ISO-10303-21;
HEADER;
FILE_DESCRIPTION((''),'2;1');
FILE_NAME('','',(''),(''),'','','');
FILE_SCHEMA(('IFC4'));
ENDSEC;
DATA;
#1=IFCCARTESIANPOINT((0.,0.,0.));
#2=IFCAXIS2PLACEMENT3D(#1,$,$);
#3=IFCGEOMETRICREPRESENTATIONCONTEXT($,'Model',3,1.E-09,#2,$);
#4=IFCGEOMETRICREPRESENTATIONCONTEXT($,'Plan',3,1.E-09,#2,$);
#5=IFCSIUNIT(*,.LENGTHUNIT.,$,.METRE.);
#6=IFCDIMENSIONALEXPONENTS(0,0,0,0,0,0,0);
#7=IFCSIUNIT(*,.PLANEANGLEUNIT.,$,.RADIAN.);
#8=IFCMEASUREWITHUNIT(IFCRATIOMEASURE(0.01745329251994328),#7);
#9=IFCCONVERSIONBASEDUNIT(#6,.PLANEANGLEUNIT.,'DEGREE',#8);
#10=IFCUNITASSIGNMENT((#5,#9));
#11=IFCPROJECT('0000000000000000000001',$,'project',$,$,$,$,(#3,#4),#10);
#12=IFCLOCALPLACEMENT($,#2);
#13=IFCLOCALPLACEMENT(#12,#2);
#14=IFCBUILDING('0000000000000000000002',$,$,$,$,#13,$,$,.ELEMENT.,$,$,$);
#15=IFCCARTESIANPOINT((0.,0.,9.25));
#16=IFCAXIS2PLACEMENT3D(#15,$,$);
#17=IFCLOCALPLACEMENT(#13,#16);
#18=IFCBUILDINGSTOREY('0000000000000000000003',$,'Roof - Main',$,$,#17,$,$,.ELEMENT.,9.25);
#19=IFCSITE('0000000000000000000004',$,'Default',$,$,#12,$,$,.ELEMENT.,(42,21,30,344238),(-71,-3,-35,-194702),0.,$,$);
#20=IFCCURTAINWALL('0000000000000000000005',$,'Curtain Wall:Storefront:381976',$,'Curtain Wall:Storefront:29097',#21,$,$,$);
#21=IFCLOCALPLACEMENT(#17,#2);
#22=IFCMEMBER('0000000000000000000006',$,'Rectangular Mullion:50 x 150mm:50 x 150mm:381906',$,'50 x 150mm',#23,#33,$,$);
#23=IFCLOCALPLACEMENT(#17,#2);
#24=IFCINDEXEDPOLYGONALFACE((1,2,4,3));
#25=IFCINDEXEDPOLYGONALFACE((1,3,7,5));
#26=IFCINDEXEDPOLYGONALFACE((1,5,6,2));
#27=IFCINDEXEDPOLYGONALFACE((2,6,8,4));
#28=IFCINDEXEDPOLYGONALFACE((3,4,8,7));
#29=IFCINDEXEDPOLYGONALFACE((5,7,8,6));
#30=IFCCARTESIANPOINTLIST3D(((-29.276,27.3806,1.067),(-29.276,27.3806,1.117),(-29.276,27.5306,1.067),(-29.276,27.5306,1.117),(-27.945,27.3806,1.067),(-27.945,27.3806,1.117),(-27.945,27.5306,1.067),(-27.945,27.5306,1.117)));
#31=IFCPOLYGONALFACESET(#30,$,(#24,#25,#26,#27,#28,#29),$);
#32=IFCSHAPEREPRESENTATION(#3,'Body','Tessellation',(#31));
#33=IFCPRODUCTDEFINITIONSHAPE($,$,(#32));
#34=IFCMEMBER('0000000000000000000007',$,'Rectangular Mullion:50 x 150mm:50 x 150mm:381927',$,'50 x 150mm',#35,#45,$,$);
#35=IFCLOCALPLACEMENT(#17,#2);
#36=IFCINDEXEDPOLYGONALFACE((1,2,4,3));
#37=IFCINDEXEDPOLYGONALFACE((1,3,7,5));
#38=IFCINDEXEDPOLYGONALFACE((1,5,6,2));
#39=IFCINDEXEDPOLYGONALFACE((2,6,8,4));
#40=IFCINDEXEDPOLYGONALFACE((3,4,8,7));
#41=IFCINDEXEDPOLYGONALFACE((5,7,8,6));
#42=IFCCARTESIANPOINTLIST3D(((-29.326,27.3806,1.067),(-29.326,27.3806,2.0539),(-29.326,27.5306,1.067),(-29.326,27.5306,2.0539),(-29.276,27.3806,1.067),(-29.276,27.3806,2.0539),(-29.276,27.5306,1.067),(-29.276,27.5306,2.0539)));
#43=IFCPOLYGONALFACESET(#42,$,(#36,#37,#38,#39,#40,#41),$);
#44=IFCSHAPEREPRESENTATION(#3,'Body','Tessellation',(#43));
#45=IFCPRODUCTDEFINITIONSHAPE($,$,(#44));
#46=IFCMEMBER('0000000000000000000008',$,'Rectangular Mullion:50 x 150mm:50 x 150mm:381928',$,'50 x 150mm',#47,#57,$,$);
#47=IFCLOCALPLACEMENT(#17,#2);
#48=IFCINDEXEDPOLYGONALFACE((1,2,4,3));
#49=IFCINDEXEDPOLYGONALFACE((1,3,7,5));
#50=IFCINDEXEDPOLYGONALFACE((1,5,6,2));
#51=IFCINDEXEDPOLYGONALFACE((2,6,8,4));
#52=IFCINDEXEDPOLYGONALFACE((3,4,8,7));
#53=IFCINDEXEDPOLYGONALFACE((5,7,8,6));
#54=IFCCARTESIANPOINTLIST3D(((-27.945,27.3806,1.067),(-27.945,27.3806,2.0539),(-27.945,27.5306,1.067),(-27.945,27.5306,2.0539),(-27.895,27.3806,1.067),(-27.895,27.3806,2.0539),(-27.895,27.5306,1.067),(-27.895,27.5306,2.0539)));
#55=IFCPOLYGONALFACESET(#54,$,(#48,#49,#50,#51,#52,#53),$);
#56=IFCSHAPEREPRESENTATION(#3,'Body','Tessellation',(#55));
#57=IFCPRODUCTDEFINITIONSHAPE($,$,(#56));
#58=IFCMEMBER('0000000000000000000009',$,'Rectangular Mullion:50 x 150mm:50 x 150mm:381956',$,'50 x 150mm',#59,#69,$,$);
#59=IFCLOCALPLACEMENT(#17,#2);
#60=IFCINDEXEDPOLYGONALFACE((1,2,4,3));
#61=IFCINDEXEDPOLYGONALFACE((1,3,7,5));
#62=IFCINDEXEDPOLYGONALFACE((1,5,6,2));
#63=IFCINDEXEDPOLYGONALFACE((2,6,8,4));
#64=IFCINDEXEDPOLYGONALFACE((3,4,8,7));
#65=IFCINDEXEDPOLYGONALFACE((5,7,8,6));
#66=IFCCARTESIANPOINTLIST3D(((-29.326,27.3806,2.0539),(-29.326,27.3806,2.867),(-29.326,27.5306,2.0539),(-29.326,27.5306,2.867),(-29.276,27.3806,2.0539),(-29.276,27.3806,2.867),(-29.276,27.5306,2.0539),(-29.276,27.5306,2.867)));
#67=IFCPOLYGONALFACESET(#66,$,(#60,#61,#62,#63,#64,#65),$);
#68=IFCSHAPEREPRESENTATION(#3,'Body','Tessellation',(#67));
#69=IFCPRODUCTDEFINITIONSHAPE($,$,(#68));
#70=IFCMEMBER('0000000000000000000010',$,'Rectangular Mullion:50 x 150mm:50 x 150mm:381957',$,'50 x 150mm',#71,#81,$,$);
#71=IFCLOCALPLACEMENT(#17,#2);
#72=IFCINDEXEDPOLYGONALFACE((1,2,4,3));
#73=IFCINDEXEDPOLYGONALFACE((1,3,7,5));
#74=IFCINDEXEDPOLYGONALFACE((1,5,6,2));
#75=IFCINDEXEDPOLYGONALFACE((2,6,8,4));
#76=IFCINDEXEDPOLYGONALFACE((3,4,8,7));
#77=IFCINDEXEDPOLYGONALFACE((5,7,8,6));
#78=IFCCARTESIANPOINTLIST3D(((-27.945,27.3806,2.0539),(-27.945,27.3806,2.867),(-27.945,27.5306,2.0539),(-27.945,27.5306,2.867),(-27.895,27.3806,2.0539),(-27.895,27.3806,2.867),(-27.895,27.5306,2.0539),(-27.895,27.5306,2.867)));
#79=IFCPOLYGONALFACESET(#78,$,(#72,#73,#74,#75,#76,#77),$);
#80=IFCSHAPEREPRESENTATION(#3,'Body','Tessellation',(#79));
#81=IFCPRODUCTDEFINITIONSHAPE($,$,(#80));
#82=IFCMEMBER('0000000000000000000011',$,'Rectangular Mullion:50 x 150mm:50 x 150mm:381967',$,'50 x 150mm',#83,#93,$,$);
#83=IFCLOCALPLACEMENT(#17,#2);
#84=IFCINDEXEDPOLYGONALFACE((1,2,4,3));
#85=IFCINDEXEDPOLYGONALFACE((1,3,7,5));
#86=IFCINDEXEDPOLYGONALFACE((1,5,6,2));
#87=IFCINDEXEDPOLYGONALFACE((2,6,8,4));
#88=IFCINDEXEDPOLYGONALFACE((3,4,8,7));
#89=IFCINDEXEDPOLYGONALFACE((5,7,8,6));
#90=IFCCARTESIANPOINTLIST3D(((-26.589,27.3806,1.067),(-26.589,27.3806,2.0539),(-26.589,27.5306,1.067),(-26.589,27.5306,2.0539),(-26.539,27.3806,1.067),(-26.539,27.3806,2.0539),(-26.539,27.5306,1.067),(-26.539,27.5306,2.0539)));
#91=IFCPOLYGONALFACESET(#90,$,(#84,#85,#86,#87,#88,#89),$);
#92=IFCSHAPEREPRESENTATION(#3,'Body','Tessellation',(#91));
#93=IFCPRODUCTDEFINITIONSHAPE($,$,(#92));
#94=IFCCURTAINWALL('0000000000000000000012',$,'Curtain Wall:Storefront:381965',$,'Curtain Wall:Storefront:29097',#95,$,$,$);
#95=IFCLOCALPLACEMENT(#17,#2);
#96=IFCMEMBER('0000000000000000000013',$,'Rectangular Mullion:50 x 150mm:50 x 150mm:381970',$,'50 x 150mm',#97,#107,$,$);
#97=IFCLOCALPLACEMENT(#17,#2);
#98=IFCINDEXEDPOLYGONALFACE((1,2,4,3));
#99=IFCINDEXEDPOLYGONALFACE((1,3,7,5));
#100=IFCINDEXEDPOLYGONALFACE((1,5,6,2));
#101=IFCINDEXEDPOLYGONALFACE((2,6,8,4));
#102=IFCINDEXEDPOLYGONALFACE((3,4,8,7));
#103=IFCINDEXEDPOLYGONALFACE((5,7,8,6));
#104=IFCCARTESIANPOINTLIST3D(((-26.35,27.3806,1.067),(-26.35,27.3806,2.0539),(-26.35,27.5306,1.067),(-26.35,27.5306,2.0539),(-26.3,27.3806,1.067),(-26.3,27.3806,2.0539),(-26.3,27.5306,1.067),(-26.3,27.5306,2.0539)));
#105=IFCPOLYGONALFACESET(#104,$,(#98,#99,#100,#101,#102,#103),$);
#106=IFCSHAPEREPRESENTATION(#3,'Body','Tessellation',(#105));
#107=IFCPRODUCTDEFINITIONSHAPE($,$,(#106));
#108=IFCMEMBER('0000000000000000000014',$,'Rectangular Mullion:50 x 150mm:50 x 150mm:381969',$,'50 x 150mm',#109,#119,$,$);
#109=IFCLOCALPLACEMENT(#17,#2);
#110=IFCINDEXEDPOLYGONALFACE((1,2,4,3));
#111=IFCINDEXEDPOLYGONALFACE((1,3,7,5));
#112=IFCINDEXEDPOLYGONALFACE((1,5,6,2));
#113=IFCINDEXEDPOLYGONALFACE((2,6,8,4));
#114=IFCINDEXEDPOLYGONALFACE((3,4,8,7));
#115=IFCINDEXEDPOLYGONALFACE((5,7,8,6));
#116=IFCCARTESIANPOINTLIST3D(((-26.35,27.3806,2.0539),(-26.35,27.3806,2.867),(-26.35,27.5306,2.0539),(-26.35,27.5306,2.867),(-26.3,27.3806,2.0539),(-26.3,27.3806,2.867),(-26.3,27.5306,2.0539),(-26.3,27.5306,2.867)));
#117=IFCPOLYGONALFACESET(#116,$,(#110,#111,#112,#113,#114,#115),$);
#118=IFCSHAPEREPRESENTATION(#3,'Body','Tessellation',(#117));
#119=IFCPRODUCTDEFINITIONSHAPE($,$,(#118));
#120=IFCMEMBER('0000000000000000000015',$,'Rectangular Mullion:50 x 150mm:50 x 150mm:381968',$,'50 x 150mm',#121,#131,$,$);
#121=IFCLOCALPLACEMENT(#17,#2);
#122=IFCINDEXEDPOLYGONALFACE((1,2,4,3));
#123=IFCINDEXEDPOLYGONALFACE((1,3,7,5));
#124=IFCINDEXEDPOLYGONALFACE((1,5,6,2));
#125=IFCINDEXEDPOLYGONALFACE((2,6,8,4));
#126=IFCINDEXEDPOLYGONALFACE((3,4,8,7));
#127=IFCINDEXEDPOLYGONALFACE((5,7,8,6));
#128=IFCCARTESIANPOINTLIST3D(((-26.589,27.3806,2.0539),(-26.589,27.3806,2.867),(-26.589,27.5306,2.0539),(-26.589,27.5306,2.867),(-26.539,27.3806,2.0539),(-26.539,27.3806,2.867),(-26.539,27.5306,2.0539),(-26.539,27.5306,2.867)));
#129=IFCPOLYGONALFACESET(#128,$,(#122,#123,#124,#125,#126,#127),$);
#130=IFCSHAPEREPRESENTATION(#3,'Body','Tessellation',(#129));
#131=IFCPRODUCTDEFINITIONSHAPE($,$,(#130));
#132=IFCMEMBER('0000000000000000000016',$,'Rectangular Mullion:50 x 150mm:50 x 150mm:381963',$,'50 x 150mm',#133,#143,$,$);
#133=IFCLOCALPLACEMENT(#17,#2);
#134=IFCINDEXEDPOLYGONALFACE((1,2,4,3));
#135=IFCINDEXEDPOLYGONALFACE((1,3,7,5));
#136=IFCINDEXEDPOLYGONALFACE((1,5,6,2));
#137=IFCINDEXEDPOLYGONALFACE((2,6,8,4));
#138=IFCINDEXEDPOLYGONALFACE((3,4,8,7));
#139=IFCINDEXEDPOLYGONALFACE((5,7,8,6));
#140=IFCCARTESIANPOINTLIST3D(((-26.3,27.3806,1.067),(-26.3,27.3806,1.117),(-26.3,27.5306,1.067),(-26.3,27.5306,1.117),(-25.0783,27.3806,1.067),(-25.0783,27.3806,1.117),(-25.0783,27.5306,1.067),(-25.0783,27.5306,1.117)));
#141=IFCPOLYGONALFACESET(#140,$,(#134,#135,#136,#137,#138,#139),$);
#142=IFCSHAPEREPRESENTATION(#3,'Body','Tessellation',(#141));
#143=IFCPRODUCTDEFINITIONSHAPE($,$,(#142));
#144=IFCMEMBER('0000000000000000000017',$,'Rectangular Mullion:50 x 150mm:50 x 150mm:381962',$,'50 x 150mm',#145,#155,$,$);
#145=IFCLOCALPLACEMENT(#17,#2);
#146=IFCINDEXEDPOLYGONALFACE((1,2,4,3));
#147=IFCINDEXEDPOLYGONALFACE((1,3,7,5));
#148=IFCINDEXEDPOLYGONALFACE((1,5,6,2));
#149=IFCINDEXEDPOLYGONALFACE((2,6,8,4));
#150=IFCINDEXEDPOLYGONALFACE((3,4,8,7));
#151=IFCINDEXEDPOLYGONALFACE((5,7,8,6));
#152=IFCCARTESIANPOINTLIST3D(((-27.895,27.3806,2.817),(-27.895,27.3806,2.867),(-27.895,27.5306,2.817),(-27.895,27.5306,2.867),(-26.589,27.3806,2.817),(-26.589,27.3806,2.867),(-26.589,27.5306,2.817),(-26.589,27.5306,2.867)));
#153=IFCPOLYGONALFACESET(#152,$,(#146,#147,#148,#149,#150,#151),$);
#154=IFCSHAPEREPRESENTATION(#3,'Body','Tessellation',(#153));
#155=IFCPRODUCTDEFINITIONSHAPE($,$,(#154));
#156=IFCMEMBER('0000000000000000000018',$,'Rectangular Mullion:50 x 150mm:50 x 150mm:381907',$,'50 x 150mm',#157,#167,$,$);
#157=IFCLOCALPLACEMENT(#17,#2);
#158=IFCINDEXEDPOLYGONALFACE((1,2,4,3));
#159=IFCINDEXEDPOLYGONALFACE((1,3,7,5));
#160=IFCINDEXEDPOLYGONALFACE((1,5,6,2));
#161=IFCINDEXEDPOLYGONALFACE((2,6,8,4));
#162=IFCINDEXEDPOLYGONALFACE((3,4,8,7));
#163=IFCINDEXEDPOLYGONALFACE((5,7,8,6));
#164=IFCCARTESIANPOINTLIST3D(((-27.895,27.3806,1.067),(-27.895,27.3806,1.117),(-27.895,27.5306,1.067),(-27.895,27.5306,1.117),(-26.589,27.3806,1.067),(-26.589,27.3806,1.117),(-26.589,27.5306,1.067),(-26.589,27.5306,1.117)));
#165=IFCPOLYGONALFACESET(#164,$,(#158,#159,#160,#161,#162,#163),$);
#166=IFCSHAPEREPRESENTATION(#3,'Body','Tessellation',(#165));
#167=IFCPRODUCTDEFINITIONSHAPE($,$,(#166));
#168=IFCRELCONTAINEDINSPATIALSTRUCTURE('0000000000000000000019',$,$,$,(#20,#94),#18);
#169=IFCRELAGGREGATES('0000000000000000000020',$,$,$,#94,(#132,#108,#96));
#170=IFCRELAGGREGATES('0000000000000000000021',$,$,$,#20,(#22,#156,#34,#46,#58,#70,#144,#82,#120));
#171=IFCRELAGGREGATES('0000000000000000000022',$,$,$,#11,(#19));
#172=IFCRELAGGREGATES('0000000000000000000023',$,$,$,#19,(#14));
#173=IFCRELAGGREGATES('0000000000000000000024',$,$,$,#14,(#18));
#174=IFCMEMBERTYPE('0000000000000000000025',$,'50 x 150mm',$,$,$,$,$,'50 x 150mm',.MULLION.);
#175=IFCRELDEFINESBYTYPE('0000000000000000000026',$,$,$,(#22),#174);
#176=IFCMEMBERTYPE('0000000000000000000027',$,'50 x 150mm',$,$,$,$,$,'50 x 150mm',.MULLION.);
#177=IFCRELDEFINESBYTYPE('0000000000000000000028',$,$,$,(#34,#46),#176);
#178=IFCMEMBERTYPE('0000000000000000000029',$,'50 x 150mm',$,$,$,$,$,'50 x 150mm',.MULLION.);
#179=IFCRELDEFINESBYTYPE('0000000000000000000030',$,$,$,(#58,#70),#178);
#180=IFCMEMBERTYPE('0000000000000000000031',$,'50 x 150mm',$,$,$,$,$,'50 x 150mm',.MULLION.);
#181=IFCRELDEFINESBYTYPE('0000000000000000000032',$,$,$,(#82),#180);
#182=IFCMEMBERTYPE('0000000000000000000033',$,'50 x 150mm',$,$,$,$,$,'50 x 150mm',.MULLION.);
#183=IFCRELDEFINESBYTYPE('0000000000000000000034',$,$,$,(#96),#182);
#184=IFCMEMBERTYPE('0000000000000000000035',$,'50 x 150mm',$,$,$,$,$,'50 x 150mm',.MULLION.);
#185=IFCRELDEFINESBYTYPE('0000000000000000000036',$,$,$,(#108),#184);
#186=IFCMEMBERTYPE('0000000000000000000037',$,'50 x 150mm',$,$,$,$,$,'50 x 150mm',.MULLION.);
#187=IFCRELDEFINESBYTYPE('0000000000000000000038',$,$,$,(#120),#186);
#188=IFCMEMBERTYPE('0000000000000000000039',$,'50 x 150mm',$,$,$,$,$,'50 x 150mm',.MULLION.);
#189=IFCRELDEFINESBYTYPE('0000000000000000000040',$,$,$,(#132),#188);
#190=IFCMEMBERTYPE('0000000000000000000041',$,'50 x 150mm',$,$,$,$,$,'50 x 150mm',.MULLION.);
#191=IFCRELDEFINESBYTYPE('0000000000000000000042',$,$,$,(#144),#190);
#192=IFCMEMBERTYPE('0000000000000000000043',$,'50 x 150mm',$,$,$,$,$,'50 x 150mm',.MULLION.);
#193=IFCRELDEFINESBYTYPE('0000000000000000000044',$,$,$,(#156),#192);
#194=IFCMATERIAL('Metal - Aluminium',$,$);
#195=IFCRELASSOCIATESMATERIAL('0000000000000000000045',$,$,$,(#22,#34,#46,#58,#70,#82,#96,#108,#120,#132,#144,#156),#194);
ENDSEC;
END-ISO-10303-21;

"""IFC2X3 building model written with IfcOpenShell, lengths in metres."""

from ifc_helpers import new_model, entity, si_unit, converted_unit, frame, origin, origin_2d_with_axis, place, context, project, spatial, rectangle, extrude, source, transform, mapped, material, type_object, type_shapes, element, aggregate, save


model = new_model("IFC2X3")

# Units and contexts
model_context = context("Model", 3, precision=1e-09, world=origin())
plan_context = context("Plan", 3, precision=1e-09, world=origin())
ifc_project = project(units=[si_unit("LENGTHUNIT", "METRE"), converted_unit("PLANEANGLEUNIT", "DEGREE", entity("IfcRatioMeasure", 0.01745329251994328), si_unit("PLANEANGLEUNIT", "RADIAN"), dimensions=[0, 0, 0, 0, 0, 0, 0])], contexts=[model_context, plan_context])

# Site, building, storey
site_placement = place(None, origin())
site = spatial("IfcSite", under=ifc_project, at=site_placement, Name="Default", CompositionType="ELEMENT", RefLatitude=(42, 21, 30, 344238), RefLongitude=(-71, -3, -35, -194702), RefElevation=0.0)
building_placement = place(site_placement, origin())
building = spatial("IfcBuilding", under=site, at=building_placement, CompositionType="ELEMENT")
storey_placement = place(building_placement, frame((0.0, 0.0, 9.25)))
storey = spatial("IfcBuildingStorey", under=building, at=storey_placement, Name="Roof - Main", CompositionType="ELEMENT", Elevation=9.25)

# Curtain walls, members
curtain_wall_1_placement = place(storey_placement, origin())
curtain_wall_1 = element("IfcCurtainWall", 1, at=curtain_wall_1_placement, inside=storey, Name="Curtain Wall:Storefront:381976", ObjectType="Curtain Wall:Storefront:29097")
ifc_material_1 = material(Name="Metal - Aluminium")
member_type_1 = type_object("IfcMemberType", Name="50 x 150mm", ElementType="50 x 150mm", PredefinedType="MULLION")
shared_shape_1 = source(origin(), model_context, "Body", "SweptSolid", [
    extrude(rectangle(XDim=0.05, YDim=0.15, at=origin_2d_with_axis()), frame((-0.025, 0.0, -1.331), z_axis=(0.0, 0.0, 1.0), x_axis=(-1.0, 0.0, 0.0)), (0.0, 0.0, 1.0), 1.331),
])
type_shapes(member_type_1, [shared_shape_1])
member_1_placement = place(storey_placement, frame((-29.276, 27.4556, 1.067), z_axis=(-1.0, 0.0, 0.0), x_axis=(0.0, 0.0, -1.0)))
member_1 = element("IfcMember", 2, at=member_1_placement, type_object=member_type_1, material=ifc_material_1, Name="Rectangular Mullion:50 x 150mm:50 x 150mm:381906", ObjectType="50 x 150mm", context=model_context, shape_type="MappedRepresentation", body=[
    mapped(shared_shape_1, transform((0.0, 0.0, 0.0), scale=1.0)),
])
member_type_2 = type_object("IfcMemberType", Name="50 x 150mm", ElementType="50 x 150mm", PredefinedType="MULLION")
shared_shape_2 = source(origin(), model_context, "Body", "SweptSolid", [
    extrude(rectangle(XDim=0.05, YDim=0.15, at=origin_2d_with_axis()), frame((0.0, 0.0, -0.9869), z_axis=(0.0, 0.0, 1.0), x_axis=(-1.0, 0.0, 0.0)), (0.0, 0.0, 1.0), 0.9869),
])
type_shapes(member_type_2, [shared_shape_2])
member_2_placement = place(storey_placement, frame((-29.301, 27.4556, 1.067), z_axis=(0.0, 0.0, -1.0), x_axis=(1.0, 0.0, 0.0)))
member_2 = element("IfcMember", 3, at=member_2_placement, type_object=member_type_2, material=ifc_material_1, Name="Rectangular Mullion:50 x 150mm:50 x 150mm:381927", ObjectType="50 x 150mm", context=model_context, shape_type="MappedRepresentation", body=[
    mapped(shared_shape_2, transform((0.0, 0.0, 0.0), scale=1.0)),
])
member_3_placement = place(storey_placement, frame((-27.92, 27.4556, 1.067), z_axis=(0.0, 0.0, -1.0), x_axis=(1.0, 0.0, 0.0)))
member_3 = element("IfcMember", 4, at=member_3_placement, type_object=member_type_2, material=ifc_material_1, Name="Rectangular Mullion:50 x 150mm:50 x 150mm:381928", ObjectType="50 x 150mm", context=model_context, shape_type="MappedRepresentation", body=[
    mapped(shared_shape_2, transform((0.0, 0.0, 0.0), scale=1.0)),
])
member_type_3 = type_object("IfcMemberType", Name="50 x 150mm", ElementType="50 x 150mm", PredefinedType="MULLION")
shared_shape_3 = source(origin(), model_context, "Body", "SweptSolid", [
    extrude(rectangle(XDim=0.05, YDim=0.15, at=origin_2d_with_axis()), frame((0.0, 0.0, -0.8131), z_axis=(0.0, 0.0, 1.0), x_axis=(-1.0, 0.0, 0.0)), (0.0, 0.0, 1.0), 0.8131),
])
type_shapes(member_type_3, [shared_shape_3])
member_4_placement = place(storey_placement, frame((-29.301, 27.4556, 2.0539), z_axis=(0.0, 0.0, -1.0), x_axis=(1.0, 0.0, 0.0)))
member_4 = element("IfcMember", 5, at=member_4_placement, type_object=member_type_3, material=ifc_material_1, Name="Rectangular Mullion:50 x 150mm:50 x 150mm:381956", ObjectType="50 x 150mm", context=model_context, shape_type="MappedRepresentation", body=[
    mapped(shared_shape_3, transform((0.0, 0.0, 0.0), scale=1.0)),
])
member_5_placement = place(storey_placement, frame((-27.92, 27.4556, 2.0539), z_axis=(0.0, 0.0, -1.0), x_axis=(1.0, 0.0, 0.0)))
member_5 = element("IfcMember", 6, at=member_5_placement, type_object=member_type_3, material=ifc_material_1, Name="Rectangular Mullion:50 x 150mm:50 x 150mm:381957", ObjectType="50 x 150mm", context=model_context, shape_type="MappedRepresentation", body=[
    mapped(shared_shape_3, transform((0.0, 0.0, 0.0), scale=1.0)),
])
member_type_4 = type_object("IfcMemberType", Name="50 x 150mm", ElementType="50 x 150mm", PredefinedType="MULLION")
shared_shape_4 = source(origin(), model_context, "Body", "SweptSolid", [
    extrude(rectangle(XDim=0.05, YDim=0.15, at=origin_2d_with_axis()), frame((-0.025, 0.0, -0.9869), z_axis=(0.0, 0.0, 1.0), x_axis=(-1.0, 0.0, 0.0)), (0.0, 0.0, 1.0), 0.9869),
])
type_shapes(member_type_4, [shared_shape_4])
member_6_placement = place(storey_placement, frame((-26.539, 27.4556, 1.067), z_axis=(0.0, 0.0, -1.0), x_axis=(1.0, 0.0, 0.0)))
member_6 = element("IfcMember", 7, at=member_6_placement, type_object=member_type_4, material=ifc_material_1, Name="Rectangular Mullion:50 x 150mm:50 x 150mm:381967", ObjectType="50 x 150mm", context=model_context, shape_type="MappedRepresentation", body=[
    mapped(shared_shape_4, transform((0.0, 0.0, 0.0), scale=1.0)),
])
curtain_wall_2_placement = place(storey_placement, origin())
curtain_wall_2 = element("IfcCurtainWall", 8, at=curtain_wall_2_placement, inside=storey, Name="Curtain Wall:Storefront:381965", ObjectType="Curtain Wall:Storefront:29097")
member_type_5 = type_object("IfcMemberType", Name="50 x 150mm", ElementType="50 x 150mm", PredefinedType="MULLION")
shared_shape_5 = source(origin(), model_context, "Body", "SweptSolid", [
    extrude(rectangle(XDim=0.05, YDim=0.15, at=origin_2d_with_axis()), frame((-0.025, 0.0, -0.9869), z_axis=(0.0, 0.0, 1.0), x_axis=(-1.0, 0.0, 0.0)), (0.0, 0.0, 1.0), 0.9869),
])
type_shapes(member_type_5, [shared_shape_5])
member_7_placement = place(storey_placement, frame((-26.35, 27.4556, 2.0539), z_axis=(0.0, 0.0, 1.0), x_axis=(-1.0, 0.0, 0.0)))
member_7 = element("IfcMember", 9, at=member_7_placement, type_object=member_type_5, material=ifc_material_1, Name="Rectangular Mullion:50 x 150mm:50 x 150mm:381970", ObjectType="50 x 150mm", context=model_context, shape_type="MappedRepresentation", body=[
    mapped(shared_shape_5, transform((0.0, 0.0, 0.0), scale=1.0)),
])
member_type_6 = type_object("IfcMemberType", Name="50 x 150mm", ElementType="50 x 150mm", PredefinedType="MULLION")
shared_shape_6 = source(origin(), model_context, "Body", "SweptSolid", [
    extrude(rectangle(XDim=0.05, YDim=0.15, at=origin_2d_with_axis()), frame((-0.025, 0.0, -0.8131), z_axis=(0.0, 0.0, 1.0), x_axis=(-1.0, 0.0, 0.0)), (0.0, 0.0, 1.0), 0.8131),
])
type_shapes(member_type_6, [shared_shape_6])
member_8_placement = place(storey_placement, frame((-26.35, 27.4556, 2.867), z_axis=(0.0, 0.0, 1.0), x_axis=(-1.0, 0.0, 0.0)))
member_8 = element("IfcMember", 10, at=member_8_placement, type_object=member_type_6, material=ifc_material_1, Name="Rectangular Mullion:50 x 150mm:50 x 150mm:381969", ObjectType="50 x 150mm", context=model_context, shape_type="MappedRepresentation", body=[
    mapped(shared_shape_6, transform((0.0, 0.0, 0.0), scale=1.0)),
])

# Members
member_type_7 = type_object("IfcMemberType", Name="50 x 150mm", ElementType="50 x 150mm", PredefinedType="MULLION")
shared_shape_7 = source(origin(), model_context, "Body", "SweptSolid", [
    extrude(rectangle(XDim=0.05, YDim=0.15, at=origin_2d_with_axis()), frame((-0.025, 0.0, -0.8131), z_axis=(0.0, 0.0, 1.0), x_axis=(-1.0, 0.0, 0.0)), (0.0, 0.0, 1.0), 0.8131),
])
type_shapes(member_type_7, [shared_shape_7])
member_9_placement = place(storey_placement, frame((-26.539, 27.4556, 2.0539), z_axis=(0.0, 0.0, -1.0), x_axis=(1.0, 0.0, 0.0)))
member_9 = element("IfcMember", 11, at=member_9_placement, type_object=member_type_7, material=ifc_material_1, Name="Rectangular Mullion:50 x 150mm:50 x 150mm:381968", ObjectType="50 x 150mm", context=model_context, shape_type="MappedRepresentation", body=[
    mapped(shared_shape_7, transform((0.0, 0.0, 0.0), scale=1.0)),
])
member_type_8 = type_object("IfcMemberType", Name="50 x 150mm", ElementType="50 x 150mm", PredefinedType="MULLION")
shared_shape_8 = source(origin(), model_context, "Body", "SweptSolid", [
    extrude(rectangle(XDim=0.05, YDim=0.15, at=origin_2d_with_axis()), frame((-0.025, 0.0, -1.2217), z_axis=(0.0, 0.0, 1.0), x_axis=(-1.0, 0.0, 0.0)), (0.0, 0.0, 1.0), 1.2217),
])
type_shapes(member_type_8, [shared_shape_8])
member_10_placement = place(storey_placement, frame((-26.3, 27.4556, 1.067), z_axis=(-1.0, 0.0, 0.0), x_axis=(0.0, 0.0, -1.0)))
member_10 = element("IfcMember", 12, at=member_10_placement, type_object=member_type_8, material=ifc_material_1, Name="Rectangular Mullion:50 x 150mm:50 x 150mm:381963", ObjectType="50 x 150mm", context=model_context, shape_type="MappedRepresentation", body=[
    mapped(shared_shape_8, transform((0.0, 0.0, 0.0), scale=1.0)),
])
member_type_9 = type_object("IfcMemberType", Name="50 x 150mm", ElementType="50 x 150mm", PredefinedType="MULLION")
shared_shape_9 = source(origin(), model_context, "Body", "SweptSolid", [
    extrude(rectangle(XDim=0.05, YDim=0.15, at=origin_2d_with_axis()), frame((-0.025, 0.0, -1.306), z_axis=(0.0, 0.0, 1.0), x_axis=(-1.0, 0.0, 0.0)), (0.0, 0.0, 1.0), 1.306),
])
type_shapes(member_type_9, [shared_shape_9])
member_11_placement = place(storey_placement, frame((-26.589, 27.4556, 2.867), z_axis=(1.0, 0.0, 0.0), x_axis=(0.0, 0.0, 1.0)))
member_11 = element("IfcMember", 13, at=member_11_placement, type_object=member_type_9, material=ifc_material_1, Name="Rectangular Mullion:50 x 150mm:50 x 150mm:381962", ObjectType="50 x 150mm", context=model_context, shape_type="MappedRepresentation", body=[
    mapped(shared_shape_9, transform((0.0, 0.0, 0.0), scale=1.0)),
])
member_type_10 = type_object("IfcMemberType", Name="50 x 150mm", ElementType="50 x 150mm", PredefinedType="MULLION")
shared_shape_10 = source(origin(), model_context, "Body", "SweptSolid", [
    extrude(rectangle(XDim=0.05, YDim=0.15, at=origin_2d_with_axis()), frame((-0.025, 0.0, -1.306), z_axis=(0.0, 0.0, 1.0), x_axis=(-1.0, 0.0, 0.0)), (0.0, 0.0, 1.0), 1.306),
])
type_shapes(member_type_10, [shared_shape_10])
member_12_placement = place(storey_placement, frame((-27.895, 27.4556, 1.067), z_axis=(-1.0, 0.0, 0.0), x_axis=(0.0, 0.0, -1.0)))
member_12 = element("IfcMember", 14, at=member_12_placement, type_object=member_type_10, material=ifc_material_1, Name="Rectangular Mullion:50 x 150mm:50 x 150mm:381907", ObjectType="50 x 150mm", context=model_context, shape_type="MappedRepresentation", body=[
    mapped(shared_shape_10, transform((0.0, 0.0, 0.0), scale=1.0)),
])

aggregate(curtain_wall_2, [member_10, member_8, member_7])
aggregate(curtain_wall_1, [member_1, member_12, member_2, member_3, member_4, member_5, member_11, member_6, member_9])

save(model, "model.ifc")
